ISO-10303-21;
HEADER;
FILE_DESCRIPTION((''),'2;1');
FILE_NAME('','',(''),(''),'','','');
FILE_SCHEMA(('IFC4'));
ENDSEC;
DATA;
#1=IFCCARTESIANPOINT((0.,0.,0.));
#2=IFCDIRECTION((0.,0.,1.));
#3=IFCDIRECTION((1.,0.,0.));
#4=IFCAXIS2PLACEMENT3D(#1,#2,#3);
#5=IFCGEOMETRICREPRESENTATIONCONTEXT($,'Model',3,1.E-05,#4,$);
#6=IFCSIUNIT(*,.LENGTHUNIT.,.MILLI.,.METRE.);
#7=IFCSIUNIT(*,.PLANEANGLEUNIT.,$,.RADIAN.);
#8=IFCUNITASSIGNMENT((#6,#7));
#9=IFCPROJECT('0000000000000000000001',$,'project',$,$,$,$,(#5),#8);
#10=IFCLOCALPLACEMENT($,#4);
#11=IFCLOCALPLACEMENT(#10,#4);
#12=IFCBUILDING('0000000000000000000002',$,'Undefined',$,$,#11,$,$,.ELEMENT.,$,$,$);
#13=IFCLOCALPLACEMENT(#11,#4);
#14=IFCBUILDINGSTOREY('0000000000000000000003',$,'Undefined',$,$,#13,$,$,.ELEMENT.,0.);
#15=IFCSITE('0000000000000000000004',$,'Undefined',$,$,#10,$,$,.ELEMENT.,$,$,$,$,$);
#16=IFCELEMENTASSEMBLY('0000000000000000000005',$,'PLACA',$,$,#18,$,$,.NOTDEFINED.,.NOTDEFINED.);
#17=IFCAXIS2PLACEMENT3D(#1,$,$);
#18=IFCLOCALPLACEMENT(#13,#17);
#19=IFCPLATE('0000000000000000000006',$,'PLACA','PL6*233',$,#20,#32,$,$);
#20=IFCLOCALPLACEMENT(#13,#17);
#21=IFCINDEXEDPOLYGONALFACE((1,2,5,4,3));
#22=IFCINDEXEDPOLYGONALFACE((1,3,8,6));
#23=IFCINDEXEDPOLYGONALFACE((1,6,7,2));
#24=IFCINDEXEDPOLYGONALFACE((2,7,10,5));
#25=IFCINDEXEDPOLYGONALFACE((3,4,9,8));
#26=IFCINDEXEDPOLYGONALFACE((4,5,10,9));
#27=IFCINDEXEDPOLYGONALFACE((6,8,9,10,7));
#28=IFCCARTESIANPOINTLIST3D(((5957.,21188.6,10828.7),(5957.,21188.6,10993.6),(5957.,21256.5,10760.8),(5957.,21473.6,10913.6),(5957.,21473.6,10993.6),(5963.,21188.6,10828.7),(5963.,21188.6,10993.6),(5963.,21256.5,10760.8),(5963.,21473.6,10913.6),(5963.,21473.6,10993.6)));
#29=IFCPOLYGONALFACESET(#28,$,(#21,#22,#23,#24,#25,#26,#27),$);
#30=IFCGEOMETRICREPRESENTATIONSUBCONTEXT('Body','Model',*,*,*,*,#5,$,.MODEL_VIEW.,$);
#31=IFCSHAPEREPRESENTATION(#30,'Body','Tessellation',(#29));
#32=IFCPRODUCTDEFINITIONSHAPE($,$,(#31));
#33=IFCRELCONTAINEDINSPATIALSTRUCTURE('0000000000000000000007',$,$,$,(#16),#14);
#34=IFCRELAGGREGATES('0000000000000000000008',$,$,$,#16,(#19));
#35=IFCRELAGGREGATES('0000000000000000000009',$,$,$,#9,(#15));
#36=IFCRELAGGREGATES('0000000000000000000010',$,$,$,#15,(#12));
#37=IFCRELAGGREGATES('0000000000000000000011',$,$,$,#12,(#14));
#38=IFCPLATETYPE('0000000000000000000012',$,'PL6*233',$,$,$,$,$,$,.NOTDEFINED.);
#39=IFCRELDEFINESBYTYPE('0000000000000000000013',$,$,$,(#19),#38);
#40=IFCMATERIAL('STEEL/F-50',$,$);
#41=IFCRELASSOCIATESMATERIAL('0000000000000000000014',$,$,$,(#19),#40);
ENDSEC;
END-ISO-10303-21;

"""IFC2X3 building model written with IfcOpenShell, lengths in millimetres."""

from ifc_helpers import new_model, si_unit, frame, origin_with_axes, place, context, subcontext, project, spatial, polyline, outline, extrude, material, type_object, element, aggregate, save


model = new_model("IFC2X3")

# Units and contexts
model_context = context("Model", 3, precision=1e-05, world=origin_with_axes())
body_context = subcontext(model_context, "Body", "Model", "MODEL_VIEW")
ifc_project = project(units=[si_unit("LENGTHUNIT", "METRE", prefix="MILLI"), si_unit("PLANEANGLEUNIT", "RADIAN")], contexts=[model_context])

# Site, building, storey
site_placement = place(None, origin_with_axes())
site = spatial("IfcSite", under=ifc_project, at=site_placement, Name="Undefined", CompositionType="ELEMENT")
building_placement = place(site_placement, origin_with_axes())
building = spatial("IfcBuilding", under=site, at=building_placement, Name="Undefined", CompositionType="ELEMENT")
storey_placement = place(building_placement, origin_with_axes())
storey = spatial("IfcBuildingStorey", under=building, at=storey_placement, Name="Undefined", CompositionType="ELEMENT", Elevation=0.0)

# Shared definitions
ifc_material_1 = material(Name="STEEL/F-50")

# Element assembly, plate
assembly_1_placement = place(storey_placement, origin_with_axes())
assembly_1 = element("IfcElementAssembly", 1, at=assembly_1_placement, inside=storey, Name="PLACA", AssemblyPlace="NOTDEFINED", PredefinedType="NOTDEFINED")
plate_type_1 = type_object("IfcPlateType", Name="PL6*233", PredefinedType="NOTDEFINED")
plate_1_placement = place(assembly_1_placement, frame((5960.0, 21188.6, 10993.6), z_axis=(1.0, 0.0, 0.0), x_axis=(0.0, 0.0, -1.0)))
plate_1 = element("IfcPlate", 2, at=plate_1_placement, type_object=plate_type_1, material=ifc_material_1, Name="PLACA", Description="PL6*233", context=body_context, shape_type="SweptSolid", body=[
    extrude(outline(polyline([(0.0, 0.0), (165.0, 0.0), (232.8, 67.9), (80.0, 285.0), (0.0, 285.0), (0.0, 0.0)])), frame((0.0, 0.0, -3.0), z_axis=(0.0, 0.0, 1.0), x_axis=(1.0, 0.0, 0.0)), (0.0, 0.0, 1.0), 6.0),
])
aggregate(assembly_1, [plate_1])

save(model, "model.ifc")
